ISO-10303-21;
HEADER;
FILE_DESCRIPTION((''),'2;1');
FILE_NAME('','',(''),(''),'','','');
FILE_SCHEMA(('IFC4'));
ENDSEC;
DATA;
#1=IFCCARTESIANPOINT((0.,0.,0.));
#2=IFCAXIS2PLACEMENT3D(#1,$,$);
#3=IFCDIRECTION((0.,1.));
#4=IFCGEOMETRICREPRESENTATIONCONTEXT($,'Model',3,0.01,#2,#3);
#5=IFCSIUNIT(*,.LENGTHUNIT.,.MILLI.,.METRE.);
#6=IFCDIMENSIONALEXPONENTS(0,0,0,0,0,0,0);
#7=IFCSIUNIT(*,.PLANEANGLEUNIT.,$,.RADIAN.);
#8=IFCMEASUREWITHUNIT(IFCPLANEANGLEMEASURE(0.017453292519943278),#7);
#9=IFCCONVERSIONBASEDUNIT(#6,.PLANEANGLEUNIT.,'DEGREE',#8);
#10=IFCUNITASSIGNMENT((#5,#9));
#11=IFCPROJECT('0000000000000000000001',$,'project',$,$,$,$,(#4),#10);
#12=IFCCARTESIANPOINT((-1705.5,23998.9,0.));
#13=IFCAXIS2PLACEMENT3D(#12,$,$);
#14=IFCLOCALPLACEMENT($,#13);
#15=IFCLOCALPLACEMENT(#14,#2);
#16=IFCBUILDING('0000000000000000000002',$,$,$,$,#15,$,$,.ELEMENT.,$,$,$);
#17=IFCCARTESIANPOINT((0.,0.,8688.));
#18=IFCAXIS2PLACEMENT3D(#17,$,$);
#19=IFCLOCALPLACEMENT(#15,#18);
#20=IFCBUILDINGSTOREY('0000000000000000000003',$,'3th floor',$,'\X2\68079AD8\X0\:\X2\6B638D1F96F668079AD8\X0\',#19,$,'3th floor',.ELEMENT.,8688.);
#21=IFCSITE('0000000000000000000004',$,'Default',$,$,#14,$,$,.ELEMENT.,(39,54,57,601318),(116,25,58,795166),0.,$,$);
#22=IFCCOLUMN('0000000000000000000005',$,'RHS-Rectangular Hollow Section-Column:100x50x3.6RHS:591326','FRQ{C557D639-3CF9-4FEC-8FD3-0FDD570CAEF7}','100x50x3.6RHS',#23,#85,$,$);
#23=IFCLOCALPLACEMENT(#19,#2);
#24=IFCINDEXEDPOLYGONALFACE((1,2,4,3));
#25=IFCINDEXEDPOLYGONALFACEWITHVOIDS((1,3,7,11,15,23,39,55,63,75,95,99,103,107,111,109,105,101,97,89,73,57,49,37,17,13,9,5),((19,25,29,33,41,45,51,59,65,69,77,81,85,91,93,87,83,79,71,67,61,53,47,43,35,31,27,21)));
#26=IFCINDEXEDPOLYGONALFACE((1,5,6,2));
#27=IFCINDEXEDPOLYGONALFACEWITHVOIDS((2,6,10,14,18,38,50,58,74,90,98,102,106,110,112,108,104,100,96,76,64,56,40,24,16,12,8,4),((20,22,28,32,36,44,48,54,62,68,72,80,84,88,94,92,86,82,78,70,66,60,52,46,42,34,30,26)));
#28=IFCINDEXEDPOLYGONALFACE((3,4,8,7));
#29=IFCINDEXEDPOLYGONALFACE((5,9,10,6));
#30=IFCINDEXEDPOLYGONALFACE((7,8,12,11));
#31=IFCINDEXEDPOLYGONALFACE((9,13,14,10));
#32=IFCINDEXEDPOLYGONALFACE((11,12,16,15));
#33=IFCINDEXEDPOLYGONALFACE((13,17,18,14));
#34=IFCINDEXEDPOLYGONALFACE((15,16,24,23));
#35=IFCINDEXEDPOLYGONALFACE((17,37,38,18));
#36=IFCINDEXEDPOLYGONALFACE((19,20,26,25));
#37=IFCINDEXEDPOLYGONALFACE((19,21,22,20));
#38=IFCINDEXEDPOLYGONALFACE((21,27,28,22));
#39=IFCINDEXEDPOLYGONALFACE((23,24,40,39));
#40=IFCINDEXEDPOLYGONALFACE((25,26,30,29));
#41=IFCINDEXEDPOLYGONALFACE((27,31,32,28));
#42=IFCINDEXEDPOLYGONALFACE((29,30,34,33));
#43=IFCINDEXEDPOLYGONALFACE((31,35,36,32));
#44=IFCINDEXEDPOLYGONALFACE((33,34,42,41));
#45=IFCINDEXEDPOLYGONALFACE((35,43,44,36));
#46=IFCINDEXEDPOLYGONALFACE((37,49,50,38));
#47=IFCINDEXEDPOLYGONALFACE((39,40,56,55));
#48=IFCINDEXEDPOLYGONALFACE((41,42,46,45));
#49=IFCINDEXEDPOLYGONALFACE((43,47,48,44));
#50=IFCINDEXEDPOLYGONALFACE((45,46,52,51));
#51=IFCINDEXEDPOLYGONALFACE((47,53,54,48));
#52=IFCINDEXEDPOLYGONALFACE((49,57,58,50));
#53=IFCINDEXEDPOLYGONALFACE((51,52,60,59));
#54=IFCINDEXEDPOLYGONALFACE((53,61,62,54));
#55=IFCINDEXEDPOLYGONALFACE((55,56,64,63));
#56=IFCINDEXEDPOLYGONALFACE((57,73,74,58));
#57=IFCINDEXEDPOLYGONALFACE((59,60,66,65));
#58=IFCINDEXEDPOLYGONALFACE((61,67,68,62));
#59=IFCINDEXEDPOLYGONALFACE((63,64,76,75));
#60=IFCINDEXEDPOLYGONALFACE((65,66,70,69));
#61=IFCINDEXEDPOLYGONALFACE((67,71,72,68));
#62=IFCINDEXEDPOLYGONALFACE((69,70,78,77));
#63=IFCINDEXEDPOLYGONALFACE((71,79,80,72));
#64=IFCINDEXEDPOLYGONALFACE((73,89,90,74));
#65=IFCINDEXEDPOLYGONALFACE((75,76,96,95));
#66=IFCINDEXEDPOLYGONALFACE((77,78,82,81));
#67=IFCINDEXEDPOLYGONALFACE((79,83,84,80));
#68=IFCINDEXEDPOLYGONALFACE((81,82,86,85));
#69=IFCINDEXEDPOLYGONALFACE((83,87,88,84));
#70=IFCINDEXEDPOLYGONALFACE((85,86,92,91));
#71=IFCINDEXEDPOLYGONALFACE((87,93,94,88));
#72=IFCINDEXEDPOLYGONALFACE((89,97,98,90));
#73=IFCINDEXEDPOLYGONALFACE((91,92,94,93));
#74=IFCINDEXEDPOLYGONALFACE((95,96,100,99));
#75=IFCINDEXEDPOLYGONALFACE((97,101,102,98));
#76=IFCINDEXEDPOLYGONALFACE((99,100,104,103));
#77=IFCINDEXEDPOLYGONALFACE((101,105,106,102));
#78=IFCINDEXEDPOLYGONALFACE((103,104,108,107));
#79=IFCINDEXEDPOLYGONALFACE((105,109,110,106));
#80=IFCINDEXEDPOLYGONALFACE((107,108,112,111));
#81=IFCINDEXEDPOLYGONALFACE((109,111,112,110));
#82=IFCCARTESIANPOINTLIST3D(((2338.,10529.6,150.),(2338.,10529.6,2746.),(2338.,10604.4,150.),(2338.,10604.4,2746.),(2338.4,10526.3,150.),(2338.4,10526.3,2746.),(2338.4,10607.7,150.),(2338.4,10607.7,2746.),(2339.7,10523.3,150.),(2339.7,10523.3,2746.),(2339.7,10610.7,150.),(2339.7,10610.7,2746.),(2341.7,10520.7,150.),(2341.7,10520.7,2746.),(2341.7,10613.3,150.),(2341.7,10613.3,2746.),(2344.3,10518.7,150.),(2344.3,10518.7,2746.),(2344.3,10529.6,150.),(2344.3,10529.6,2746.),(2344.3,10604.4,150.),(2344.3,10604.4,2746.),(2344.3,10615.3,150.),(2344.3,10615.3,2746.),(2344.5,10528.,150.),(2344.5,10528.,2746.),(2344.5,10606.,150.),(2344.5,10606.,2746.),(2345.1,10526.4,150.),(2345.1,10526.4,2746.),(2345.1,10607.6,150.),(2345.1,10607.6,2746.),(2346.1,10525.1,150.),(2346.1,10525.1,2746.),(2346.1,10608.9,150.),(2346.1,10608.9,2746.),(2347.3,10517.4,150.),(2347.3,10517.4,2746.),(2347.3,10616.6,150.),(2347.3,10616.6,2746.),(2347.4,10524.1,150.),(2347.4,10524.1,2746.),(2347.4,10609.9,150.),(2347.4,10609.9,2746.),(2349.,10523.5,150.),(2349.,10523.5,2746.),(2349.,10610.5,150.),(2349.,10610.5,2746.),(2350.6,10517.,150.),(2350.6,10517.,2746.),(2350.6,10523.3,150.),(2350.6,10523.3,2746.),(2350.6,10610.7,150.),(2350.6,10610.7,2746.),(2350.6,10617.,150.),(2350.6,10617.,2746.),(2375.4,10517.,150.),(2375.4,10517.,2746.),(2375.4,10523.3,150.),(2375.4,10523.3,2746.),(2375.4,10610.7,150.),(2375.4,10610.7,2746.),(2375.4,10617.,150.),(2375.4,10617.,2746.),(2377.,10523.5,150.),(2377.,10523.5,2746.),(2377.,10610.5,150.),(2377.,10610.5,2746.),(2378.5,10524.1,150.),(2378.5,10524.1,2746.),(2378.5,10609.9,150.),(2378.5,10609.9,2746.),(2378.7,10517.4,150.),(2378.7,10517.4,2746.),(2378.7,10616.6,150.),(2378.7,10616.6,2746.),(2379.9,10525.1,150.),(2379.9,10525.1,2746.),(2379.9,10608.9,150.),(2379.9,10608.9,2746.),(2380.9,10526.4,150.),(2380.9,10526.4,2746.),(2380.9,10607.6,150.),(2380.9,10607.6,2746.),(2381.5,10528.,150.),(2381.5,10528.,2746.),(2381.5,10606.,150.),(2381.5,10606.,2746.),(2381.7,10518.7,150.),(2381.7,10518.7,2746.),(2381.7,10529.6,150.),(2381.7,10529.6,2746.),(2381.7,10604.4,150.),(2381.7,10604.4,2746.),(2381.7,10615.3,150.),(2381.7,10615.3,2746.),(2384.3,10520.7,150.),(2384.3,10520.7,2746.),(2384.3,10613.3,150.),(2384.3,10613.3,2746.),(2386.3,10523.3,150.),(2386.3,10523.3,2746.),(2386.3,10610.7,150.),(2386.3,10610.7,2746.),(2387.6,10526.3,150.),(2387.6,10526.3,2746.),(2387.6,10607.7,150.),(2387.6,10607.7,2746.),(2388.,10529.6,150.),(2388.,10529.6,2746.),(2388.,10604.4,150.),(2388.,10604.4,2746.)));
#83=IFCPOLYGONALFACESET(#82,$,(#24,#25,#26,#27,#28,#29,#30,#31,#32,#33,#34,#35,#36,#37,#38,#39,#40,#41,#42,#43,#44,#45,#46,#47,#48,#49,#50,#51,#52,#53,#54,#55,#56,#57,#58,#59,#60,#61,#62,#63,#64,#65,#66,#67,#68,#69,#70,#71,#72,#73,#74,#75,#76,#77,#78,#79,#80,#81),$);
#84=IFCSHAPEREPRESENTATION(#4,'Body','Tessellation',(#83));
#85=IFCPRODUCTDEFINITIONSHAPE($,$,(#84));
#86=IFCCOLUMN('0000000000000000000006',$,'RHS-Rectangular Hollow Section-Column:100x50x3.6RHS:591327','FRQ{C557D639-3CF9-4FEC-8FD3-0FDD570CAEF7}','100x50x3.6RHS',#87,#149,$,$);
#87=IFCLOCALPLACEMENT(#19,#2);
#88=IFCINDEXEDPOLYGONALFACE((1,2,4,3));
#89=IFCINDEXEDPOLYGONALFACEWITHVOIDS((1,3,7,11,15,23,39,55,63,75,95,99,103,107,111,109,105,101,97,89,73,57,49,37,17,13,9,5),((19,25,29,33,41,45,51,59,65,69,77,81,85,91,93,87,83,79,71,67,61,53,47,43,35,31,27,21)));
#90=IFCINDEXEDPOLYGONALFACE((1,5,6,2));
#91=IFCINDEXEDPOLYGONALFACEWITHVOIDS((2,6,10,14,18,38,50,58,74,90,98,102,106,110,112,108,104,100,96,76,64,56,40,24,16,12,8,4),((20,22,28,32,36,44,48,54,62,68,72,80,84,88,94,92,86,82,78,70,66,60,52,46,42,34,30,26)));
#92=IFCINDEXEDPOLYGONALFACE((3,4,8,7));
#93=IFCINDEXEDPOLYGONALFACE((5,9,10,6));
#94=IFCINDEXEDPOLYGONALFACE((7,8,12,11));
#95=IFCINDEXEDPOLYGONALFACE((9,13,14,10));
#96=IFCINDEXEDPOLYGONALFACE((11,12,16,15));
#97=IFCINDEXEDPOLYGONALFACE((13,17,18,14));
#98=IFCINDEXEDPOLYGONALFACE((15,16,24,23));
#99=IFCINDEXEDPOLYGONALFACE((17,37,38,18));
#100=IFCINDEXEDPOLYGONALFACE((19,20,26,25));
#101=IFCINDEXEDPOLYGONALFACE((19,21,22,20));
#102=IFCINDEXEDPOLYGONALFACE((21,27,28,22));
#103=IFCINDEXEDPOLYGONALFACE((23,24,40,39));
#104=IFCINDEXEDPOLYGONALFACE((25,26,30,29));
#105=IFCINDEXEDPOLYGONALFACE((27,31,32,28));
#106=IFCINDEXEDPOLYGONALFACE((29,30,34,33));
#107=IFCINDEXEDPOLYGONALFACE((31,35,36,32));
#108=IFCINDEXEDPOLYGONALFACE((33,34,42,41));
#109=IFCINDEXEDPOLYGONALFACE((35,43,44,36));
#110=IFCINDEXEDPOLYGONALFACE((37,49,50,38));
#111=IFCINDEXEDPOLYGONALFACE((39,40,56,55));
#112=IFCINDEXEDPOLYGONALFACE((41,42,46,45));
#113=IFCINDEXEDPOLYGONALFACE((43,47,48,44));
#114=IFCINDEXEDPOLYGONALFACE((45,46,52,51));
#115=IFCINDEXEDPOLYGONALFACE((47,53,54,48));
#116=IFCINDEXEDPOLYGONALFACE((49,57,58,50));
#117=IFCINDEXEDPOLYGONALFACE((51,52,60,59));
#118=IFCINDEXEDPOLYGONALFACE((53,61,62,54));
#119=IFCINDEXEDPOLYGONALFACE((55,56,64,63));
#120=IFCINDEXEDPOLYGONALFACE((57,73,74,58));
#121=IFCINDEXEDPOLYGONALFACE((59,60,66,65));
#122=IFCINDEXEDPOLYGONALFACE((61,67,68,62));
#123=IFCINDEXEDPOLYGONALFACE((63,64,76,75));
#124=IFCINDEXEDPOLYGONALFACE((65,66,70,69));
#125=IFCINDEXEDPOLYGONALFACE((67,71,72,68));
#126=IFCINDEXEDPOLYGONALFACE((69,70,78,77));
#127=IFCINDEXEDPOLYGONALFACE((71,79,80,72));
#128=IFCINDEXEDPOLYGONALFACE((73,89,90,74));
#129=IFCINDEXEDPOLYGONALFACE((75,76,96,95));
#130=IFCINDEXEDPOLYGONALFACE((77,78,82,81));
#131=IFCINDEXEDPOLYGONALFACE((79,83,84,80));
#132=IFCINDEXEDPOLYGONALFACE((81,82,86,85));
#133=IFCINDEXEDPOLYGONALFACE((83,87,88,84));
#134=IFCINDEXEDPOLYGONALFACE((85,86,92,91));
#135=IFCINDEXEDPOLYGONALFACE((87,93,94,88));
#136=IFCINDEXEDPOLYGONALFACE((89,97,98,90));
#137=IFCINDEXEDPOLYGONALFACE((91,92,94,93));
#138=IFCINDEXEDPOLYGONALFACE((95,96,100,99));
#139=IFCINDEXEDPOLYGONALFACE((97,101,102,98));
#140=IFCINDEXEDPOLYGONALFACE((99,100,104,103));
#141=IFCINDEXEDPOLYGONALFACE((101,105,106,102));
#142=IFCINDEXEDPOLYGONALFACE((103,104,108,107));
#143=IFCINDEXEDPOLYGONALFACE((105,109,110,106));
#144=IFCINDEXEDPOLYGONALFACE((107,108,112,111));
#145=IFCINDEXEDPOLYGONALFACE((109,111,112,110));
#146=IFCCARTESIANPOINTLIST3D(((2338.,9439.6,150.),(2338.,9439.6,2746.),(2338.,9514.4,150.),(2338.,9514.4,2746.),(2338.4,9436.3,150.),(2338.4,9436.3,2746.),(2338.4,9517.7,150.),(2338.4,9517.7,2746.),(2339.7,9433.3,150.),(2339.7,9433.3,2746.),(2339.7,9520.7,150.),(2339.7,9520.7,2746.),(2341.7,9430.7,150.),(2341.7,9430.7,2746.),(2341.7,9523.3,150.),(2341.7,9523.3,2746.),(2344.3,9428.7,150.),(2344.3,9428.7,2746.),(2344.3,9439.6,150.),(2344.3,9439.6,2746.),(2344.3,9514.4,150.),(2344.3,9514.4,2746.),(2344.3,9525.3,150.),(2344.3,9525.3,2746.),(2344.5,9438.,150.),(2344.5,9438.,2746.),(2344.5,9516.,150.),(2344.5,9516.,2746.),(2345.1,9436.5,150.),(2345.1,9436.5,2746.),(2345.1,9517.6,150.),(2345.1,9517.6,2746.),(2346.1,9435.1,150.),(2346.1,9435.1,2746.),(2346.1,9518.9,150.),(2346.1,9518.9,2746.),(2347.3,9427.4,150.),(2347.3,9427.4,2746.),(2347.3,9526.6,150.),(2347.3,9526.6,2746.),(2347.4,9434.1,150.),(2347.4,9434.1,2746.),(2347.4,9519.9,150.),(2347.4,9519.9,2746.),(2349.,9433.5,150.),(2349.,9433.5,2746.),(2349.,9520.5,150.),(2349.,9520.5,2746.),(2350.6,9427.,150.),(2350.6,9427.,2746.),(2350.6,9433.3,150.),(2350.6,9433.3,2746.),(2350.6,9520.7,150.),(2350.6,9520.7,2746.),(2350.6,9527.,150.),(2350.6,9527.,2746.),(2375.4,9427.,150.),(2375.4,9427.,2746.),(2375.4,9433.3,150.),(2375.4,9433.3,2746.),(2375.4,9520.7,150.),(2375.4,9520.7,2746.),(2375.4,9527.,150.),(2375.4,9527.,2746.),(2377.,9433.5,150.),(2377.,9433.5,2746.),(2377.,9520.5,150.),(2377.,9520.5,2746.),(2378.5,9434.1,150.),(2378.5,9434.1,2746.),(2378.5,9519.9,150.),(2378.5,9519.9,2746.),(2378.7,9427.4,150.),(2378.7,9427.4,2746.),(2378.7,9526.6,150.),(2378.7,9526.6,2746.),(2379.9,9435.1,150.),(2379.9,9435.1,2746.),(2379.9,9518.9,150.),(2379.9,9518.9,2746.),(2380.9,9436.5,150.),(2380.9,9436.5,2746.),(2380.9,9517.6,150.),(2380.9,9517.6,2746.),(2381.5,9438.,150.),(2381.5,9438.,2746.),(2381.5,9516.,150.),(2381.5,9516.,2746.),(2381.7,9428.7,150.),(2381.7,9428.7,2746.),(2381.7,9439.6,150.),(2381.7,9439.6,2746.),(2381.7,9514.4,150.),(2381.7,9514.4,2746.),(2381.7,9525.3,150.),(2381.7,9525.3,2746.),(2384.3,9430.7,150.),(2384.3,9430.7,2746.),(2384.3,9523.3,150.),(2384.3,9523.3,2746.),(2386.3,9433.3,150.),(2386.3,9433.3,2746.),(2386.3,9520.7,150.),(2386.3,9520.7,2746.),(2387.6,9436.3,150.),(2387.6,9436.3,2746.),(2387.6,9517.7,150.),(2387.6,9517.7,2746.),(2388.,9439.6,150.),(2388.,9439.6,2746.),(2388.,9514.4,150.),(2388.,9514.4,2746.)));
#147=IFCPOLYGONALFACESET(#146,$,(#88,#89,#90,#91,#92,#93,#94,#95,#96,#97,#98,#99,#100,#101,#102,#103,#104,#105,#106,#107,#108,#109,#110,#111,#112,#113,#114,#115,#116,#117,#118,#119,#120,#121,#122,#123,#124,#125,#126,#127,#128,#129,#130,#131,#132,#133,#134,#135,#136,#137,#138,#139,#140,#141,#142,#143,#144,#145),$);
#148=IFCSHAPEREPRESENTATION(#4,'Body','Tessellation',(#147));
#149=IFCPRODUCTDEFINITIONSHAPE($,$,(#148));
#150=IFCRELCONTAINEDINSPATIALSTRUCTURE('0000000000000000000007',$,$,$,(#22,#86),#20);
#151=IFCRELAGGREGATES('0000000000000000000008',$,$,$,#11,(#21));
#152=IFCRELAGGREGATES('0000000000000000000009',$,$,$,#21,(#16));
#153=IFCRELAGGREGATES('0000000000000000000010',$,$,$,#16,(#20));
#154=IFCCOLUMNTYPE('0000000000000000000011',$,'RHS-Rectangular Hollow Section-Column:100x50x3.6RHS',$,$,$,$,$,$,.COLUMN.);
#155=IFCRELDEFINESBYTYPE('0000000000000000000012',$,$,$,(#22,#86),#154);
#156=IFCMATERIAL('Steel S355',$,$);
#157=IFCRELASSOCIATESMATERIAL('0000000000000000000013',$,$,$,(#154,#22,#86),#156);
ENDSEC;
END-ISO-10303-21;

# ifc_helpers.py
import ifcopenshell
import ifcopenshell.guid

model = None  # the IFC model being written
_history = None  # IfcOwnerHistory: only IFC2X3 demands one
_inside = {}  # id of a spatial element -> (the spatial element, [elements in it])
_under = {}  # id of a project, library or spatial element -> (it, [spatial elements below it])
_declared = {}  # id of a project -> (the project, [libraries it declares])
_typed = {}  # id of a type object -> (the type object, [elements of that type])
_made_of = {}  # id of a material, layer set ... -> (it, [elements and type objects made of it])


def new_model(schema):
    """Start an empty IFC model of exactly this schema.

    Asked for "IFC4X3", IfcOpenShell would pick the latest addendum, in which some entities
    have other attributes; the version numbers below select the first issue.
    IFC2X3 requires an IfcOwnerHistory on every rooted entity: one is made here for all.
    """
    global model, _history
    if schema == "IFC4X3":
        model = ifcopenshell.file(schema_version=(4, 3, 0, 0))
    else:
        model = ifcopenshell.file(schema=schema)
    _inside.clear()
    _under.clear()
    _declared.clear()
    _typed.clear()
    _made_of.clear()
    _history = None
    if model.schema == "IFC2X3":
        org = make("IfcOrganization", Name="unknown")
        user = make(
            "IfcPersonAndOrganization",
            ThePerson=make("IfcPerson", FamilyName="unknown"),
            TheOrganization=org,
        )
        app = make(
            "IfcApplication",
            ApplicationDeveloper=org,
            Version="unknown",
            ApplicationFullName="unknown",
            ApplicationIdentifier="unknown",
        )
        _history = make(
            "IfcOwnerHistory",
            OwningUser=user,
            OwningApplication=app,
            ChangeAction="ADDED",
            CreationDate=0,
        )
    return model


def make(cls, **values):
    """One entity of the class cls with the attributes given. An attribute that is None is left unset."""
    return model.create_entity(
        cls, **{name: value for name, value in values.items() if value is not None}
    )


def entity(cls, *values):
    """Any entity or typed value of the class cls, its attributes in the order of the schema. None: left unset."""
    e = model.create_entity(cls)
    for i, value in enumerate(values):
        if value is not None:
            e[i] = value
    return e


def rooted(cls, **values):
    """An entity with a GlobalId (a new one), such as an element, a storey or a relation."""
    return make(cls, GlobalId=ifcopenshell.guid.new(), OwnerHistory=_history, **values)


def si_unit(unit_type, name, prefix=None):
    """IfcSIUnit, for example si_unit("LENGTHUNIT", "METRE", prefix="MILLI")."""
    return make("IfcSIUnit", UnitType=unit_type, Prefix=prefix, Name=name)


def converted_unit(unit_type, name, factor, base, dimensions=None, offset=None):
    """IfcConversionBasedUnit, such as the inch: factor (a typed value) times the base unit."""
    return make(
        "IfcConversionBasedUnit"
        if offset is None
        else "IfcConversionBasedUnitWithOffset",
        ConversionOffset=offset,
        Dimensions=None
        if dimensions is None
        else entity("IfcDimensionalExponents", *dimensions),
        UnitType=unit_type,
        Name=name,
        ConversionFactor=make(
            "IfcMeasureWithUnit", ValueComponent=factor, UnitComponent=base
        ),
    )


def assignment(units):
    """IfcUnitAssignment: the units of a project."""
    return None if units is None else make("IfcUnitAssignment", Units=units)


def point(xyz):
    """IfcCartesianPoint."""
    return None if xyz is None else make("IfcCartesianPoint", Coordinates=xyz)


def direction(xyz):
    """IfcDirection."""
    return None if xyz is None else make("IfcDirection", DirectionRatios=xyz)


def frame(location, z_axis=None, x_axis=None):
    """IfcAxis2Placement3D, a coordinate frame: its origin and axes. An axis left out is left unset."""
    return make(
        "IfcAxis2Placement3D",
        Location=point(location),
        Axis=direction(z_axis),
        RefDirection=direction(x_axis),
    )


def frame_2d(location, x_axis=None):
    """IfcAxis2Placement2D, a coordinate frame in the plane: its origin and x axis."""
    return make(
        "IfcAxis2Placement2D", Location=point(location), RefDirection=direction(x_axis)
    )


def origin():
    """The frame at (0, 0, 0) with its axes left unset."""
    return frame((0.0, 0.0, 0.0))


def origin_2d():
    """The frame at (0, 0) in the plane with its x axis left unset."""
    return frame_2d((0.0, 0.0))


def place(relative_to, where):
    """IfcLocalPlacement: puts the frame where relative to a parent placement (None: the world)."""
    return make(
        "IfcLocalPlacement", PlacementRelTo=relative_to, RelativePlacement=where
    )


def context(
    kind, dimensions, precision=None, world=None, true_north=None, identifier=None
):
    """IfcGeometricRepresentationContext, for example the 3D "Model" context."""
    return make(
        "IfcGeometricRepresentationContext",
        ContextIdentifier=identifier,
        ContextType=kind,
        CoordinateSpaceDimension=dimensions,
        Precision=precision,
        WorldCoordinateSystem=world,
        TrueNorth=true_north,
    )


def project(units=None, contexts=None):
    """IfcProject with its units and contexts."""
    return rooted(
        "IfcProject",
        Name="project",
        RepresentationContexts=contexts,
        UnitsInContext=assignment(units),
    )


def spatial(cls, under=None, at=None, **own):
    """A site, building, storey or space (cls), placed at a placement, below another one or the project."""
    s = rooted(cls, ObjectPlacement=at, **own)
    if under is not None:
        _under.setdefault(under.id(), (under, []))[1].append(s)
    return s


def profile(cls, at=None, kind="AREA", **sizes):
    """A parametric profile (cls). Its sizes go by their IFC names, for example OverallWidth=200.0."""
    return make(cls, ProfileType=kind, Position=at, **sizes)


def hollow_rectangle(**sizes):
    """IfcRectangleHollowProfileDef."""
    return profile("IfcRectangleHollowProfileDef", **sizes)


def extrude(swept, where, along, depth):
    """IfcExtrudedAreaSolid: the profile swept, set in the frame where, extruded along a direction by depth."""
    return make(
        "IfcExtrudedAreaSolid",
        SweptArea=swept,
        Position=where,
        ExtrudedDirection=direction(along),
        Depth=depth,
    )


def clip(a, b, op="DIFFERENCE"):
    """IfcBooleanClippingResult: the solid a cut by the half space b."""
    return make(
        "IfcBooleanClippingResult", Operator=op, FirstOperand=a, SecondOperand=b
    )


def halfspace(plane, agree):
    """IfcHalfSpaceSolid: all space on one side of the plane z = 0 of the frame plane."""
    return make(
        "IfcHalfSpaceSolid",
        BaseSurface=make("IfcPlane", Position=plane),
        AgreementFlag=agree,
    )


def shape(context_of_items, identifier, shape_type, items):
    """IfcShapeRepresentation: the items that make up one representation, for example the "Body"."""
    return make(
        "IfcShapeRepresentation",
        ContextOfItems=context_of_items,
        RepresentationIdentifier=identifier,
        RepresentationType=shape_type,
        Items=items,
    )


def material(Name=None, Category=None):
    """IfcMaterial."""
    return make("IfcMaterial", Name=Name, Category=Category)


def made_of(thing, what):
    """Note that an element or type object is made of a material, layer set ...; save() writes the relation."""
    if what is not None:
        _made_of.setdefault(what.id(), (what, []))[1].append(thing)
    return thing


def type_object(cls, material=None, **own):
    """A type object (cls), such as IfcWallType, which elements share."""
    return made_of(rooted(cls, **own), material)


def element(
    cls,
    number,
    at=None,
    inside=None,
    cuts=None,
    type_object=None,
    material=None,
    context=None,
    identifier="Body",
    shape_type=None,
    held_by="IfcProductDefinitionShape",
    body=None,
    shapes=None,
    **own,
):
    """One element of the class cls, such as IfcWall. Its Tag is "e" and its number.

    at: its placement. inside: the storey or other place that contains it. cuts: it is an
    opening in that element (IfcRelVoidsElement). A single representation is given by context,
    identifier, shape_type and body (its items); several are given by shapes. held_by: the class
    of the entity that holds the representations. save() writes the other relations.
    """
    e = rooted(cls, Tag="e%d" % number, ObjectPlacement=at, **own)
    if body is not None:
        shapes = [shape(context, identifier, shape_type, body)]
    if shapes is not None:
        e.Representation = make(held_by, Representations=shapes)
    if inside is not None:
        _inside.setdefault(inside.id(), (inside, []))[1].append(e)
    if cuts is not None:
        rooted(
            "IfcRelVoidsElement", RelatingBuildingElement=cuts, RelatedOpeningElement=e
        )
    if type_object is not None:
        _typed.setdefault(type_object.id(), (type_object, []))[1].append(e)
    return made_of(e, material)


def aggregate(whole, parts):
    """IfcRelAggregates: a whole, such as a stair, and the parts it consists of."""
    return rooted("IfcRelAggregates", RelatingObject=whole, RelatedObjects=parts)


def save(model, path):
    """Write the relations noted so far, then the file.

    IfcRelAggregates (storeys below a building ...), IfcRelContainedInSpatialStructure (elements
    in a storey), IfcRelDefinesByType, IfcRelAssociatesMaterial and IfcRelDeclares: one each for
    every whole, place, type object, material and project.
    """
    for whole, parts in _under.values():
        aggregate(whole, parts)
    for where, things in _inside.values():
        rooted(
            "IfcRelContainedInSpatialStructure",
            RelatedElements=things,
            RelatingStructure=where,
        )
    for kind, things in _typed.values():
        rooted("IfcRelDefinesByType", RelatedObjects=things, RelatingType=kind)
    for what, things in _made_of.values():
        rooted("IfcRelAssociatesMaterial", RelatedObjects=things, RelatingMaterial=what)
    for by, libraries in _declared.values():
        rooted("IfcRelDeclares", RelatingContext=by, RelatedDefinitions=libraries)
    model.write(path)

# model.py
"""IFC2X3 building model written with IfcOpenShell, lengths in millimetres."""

from ifc_helpers import new_model, entity, si_unit, converted_unit, direction, frame, origin, origin_2d, place, context, project, spatial, hollow_rectangle, extrude, clip, halfspace, material, type_object, element, save


model = new_model("IFC2X3")

# Units and contexts
model_context = context("Model", 3, precision=0.01, world=origin(), true_north=direction((0.0, 1.0)))
ifc_project = project(units=[si_unit("LENGTHUNIT", "METRE", prefix="MILLI"), converted_unit("PLANEANGLEUNIT", "DEGREE", entity("IfcPlaneAngleMeasure", 0.017453292519943278), si_unit("PLANEANGLEUNIT", "RADIAN"), dimensions=[0, 0, 0, 0, 0, 0, 0])], contexts=[model_context])

# Site, building, storey
site_placement = place(None, frame((-1705.5, 23998.9, 0.0)))
site = spatial("IfcSite", under=ifc_project, at=site_placement, Name="Default", CompositionType="ELEMENT", RefLatitude=(39, 54, 57, 601318), RefLongitude=(116, 25, 58, 795166), RefElevation=0.0)
building_placement = place(site_placement, origin())
building = spatial("IfcBuilding", under=site, at=building_placement, CompositionType="ELEMENT")
storey_placement = place(building_placement, frame((0.0, 0.0, 8688.0)))
storey = spatial("IfcBuildingStorey", under=building, at=storey_placement, Name="3th floor", ObjectType="标高:正负零标高", LongName="3th floor", CompositionType="ELEMENT", Elevation=8688.0)

# Columns
ifc_material_1 = material(Name="Steel S355")
column_type_1 = type_object("IfcColumnType", Name="RHS-Rectangular Hollow Section-Column:100x50x3.6RHS", PredefinedType="COLUMN", material=ifc_material_1)
column_1_placement = place(storey_placement, frame((2363.0, 10567.0, 2746.0), z_axis=(0.0, 0.0, 1.0), x_axis=(-1.0, 0.0, 0.0)))
element("IfcColumn", 1, at=column_1_placement, inside=storey, type_object=column_type_1, material=ifc_material_1, Name="RHS-Rectangular Hollow Section-Column:100x50x3.6RHS:591326", Description="FRQ{C557D639-3CF9-4FEC-8FD3-0FDD570CAEF7}", ObjectType="100x50x3.6RHS", context=model_context, shape_type="Clipping", body=[
    clip(extrude(hollow_rectangle(XDim=50.0, YDim=100.0, WallThickness=6.3, InnerFilletRadius=6.3, OuterFilletRadius=12.6, at=origin_2d()), origin(), (0.0, 0.0, -1.0), 2651.9), halfspace(frame((2363.0, 10567.0, -2596.0), z_axis=(0.0, 0.0, 1.0), x_axis=(-1.0, 0.0, 0.0)), True)),
])
column_2_placement = place(storey_placement, frame((2363.0, 9477.0, 2746.0), z_axis=(0.0, 0.0, 1.0), x_axis=(-1.0, 0.0, 0.0)))
element("IfcColumn", 2, at=column_2_placement, inside=storey, type_object=column_type_1, material=ifc_material_1, Name="RHS-Rectangular Hollow Section-Column:100x50x3.6RHS:591327", Description="FRQ{C557D639-3CF9-4FEC-8FD3-0FDD570CAEF7}", ObjectType="100x50x3.6RHS", context=model_context, shape_type="Clipping", body=[
    clip(extrude(hollow_rectangle(XDim=50.0, YDim=100.0, WallThickness=6.3, InnerFilletRadius=6.3, OuterFilletRadius=12.6, at=origin_2d()), origin(), (0.0, 0.0, -1.0), 2651.9), halfspace(frame((2363.0, 9477.0, -2596.0), z_axis=(0.0, 0.0, 1.0), x_axis=(-1.0, 0.0, 0.0)), True)),
])

save(model, "model.ifc")
